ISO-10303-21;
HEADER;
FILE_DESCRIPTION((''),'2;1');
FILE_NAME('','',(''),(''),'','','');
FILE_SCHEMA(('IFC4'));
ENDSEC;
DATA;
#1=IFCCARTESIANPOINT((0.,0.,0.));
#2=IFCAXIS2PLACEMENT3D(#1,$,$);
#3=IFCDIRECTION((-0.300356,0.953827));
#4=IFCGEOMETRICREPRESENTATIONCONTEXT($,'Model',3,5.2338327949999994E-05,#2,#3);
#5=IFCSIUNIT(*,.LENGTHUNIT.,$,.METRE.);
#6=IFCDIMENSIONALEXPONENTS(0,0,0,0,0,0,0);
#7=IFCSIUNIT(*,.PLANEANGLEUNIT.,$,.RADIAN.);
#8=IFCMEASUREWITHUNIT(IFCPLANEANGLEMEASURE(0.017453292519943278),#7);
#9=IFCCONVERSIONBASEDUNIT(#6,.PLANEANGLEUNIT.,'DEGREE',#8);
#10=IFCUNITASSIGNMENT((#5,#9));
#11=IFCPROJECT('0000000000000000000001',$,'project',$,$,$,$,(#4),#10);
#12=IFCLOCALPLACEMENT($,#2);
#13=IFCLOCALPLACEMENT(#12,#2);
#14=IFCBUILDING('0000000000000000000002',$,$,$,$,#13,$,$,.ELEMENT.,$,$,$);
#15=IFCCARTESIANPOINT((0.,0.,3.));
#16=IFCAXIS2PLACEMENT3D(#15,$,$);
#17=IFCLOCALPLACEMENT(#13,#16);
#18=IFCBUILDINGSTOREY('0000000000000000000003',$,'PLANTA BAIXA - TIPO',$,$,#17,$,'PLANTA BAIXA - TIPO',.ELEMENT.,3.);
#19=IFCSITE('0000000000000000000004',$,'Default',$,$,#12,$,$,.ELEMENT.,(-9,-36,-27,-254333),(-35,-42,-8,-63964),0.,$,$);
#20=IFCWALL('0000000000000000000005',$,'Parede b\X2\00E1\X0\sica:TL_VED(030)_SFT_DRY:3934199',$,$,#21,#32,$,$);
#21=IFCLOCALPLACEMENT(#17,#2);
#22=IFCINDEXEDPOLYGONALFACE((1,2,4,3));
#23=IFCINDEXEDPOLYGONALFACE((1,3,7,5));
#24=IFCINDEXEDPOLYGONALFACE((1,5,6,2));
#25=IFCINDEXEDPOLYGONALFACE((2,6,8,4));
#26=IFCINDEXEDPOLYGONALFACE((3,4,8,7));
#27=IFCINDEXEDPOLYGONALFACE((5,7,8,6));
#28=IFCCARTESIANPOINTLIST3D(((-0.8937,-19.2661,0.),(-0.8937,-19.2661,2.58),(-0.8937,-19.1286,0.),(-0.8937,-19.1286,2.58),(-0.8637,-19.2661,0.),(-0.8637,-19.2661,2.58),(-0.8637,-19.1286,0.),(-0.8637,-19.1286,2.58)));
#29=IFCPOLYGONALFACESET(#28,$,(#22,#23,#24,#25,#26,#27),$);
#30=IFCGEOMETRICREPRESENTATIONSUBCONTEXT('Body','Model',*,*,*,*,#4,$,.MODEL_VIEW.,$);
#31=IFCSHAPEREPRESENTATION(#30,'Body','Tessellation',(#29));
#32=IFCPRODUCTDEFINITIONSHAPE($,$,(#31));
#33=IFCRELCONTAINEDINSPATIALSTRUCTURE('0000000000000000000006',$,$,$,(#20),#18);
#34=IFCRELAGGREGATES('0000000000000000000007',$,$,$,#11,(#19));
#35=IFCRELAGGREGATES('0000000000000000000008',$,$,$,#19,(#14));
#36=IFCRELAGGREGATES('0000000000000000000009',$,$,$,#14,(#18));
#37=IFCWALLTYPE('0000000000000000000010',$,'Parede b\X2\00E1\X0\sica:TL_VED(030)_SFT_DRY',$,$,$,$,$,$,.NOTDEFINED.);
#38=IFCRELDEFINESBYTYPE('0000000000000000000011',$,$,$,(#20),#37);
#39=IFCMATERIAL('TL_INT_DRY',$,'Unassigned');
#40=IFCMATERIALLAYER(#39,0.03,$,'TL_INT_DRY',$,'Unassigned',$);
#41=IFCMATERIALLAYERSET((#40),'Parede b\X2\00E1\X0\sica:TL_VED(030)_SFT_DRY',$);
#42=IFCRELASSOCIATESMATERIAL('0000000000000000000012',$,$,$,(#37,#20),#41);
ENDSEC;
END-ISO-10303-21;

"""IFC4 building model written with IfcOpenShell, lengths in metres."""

from ifc_helpers import new_model, entity, si_unit, converted_unit, direction, frame, frame_2d, origin, place, context, subcontext, project, spatial, rectangle, extrude, material, layer, layer_set, layer_usage, type_object, element, save


model = new_model("IFC4")

# Units and contexts
model_context = context("Model", 3, precision=5.2338327949999994e-05, world=origin(), true_north=direction((-0.300356, 0.953827)))
body_context = subcontext(model_context, "Body", "Model", "MODEL_VIEW")
ifc_project = project(units=[si_unit("LENGTHUNIT", "METRE"), converted_unit("PLANEANGLEUNIT", "DEGREE", entity("IfcPlaneAngleMeasure", 0.017453292519943278), si_unit("PLANEANGLEUNIT", "RADIAN"), dimensions=[0, 0, 0, 0, 0, 0, 0])], contexts=[model_context])

# Site, building, storey
site_placement = place(None, origin())
site = spatial("IfcSite", under=ifc_project, at=site_placement, Name="Default", CompositionType="ELEMENT", RefLatitude=(-9, -36, -27, -254333), RefLongitude=(-35, -42, -8, -63964), RefElevation=0.0)
building_placement = place(site_placement, origin())
building = spatial("IfcBuilding", under=site, at=building_placement, CompositionType="ELEMENT")
storey_placement = place(building_placement, frame((0.0, 0.0, 3.0)))
storey = spatial("IfcBuildingStorey", under=building, at=storey_placement, Name="PLANTA BAIXA - TIPO", LongName="PLANTA BAIXA - TIPO", CompositionType="ELEMENT", Elevation=3.0)

# Wall
ifc_material_1 = material(Name="TL_INT_DRY", Category="Unassigned")
ifc_layer_1 = layer(ifc_material_1, 0.03, Name="TL_INT_DRY", Category="Unassigned")
ifc_layer_set_1 = layer_set([ifc_layer_1], Name="Parede básica:TL_VED(030)_SFT_DRY")
wall_type_1 = type_object("IfcWallType", Name="Parede básica:TL_VED(030)_SFT_DRY", PredefinedType="NOTDEFINED", material=ifc_layer_set_1)
ifc_layer_usage_1 = layer_usage(ifc_layer_set_1, "AXIS2", "NEGATIVE", 0.015)
wall_1_placement = place(storey_placement, frame((-0.8787, -19.1286, 0.0), z_axis=(0.0, 0.0, 1.0), x_axis=(0.0, -1.0, 0.0)))
element("IfcWall", 1, at=wall_1_placement, inside=storey, type_object=wall_type_1, material=ifc_layer_usage_1, Name="Parede básica:TL_VED(030)_SFT_DRY:3934199", context=body_context, shape_type="SweptSolid", body=[
    extrude(rectangle(XDim=0.1375, YDim=0.03, at=frame_2d((0.0688, 0.0), x_axis=(-1.0, 0.0))), origin(), (0.0, 0.0, 1.0), 2.58),
])

save(model, "model.ifc")
